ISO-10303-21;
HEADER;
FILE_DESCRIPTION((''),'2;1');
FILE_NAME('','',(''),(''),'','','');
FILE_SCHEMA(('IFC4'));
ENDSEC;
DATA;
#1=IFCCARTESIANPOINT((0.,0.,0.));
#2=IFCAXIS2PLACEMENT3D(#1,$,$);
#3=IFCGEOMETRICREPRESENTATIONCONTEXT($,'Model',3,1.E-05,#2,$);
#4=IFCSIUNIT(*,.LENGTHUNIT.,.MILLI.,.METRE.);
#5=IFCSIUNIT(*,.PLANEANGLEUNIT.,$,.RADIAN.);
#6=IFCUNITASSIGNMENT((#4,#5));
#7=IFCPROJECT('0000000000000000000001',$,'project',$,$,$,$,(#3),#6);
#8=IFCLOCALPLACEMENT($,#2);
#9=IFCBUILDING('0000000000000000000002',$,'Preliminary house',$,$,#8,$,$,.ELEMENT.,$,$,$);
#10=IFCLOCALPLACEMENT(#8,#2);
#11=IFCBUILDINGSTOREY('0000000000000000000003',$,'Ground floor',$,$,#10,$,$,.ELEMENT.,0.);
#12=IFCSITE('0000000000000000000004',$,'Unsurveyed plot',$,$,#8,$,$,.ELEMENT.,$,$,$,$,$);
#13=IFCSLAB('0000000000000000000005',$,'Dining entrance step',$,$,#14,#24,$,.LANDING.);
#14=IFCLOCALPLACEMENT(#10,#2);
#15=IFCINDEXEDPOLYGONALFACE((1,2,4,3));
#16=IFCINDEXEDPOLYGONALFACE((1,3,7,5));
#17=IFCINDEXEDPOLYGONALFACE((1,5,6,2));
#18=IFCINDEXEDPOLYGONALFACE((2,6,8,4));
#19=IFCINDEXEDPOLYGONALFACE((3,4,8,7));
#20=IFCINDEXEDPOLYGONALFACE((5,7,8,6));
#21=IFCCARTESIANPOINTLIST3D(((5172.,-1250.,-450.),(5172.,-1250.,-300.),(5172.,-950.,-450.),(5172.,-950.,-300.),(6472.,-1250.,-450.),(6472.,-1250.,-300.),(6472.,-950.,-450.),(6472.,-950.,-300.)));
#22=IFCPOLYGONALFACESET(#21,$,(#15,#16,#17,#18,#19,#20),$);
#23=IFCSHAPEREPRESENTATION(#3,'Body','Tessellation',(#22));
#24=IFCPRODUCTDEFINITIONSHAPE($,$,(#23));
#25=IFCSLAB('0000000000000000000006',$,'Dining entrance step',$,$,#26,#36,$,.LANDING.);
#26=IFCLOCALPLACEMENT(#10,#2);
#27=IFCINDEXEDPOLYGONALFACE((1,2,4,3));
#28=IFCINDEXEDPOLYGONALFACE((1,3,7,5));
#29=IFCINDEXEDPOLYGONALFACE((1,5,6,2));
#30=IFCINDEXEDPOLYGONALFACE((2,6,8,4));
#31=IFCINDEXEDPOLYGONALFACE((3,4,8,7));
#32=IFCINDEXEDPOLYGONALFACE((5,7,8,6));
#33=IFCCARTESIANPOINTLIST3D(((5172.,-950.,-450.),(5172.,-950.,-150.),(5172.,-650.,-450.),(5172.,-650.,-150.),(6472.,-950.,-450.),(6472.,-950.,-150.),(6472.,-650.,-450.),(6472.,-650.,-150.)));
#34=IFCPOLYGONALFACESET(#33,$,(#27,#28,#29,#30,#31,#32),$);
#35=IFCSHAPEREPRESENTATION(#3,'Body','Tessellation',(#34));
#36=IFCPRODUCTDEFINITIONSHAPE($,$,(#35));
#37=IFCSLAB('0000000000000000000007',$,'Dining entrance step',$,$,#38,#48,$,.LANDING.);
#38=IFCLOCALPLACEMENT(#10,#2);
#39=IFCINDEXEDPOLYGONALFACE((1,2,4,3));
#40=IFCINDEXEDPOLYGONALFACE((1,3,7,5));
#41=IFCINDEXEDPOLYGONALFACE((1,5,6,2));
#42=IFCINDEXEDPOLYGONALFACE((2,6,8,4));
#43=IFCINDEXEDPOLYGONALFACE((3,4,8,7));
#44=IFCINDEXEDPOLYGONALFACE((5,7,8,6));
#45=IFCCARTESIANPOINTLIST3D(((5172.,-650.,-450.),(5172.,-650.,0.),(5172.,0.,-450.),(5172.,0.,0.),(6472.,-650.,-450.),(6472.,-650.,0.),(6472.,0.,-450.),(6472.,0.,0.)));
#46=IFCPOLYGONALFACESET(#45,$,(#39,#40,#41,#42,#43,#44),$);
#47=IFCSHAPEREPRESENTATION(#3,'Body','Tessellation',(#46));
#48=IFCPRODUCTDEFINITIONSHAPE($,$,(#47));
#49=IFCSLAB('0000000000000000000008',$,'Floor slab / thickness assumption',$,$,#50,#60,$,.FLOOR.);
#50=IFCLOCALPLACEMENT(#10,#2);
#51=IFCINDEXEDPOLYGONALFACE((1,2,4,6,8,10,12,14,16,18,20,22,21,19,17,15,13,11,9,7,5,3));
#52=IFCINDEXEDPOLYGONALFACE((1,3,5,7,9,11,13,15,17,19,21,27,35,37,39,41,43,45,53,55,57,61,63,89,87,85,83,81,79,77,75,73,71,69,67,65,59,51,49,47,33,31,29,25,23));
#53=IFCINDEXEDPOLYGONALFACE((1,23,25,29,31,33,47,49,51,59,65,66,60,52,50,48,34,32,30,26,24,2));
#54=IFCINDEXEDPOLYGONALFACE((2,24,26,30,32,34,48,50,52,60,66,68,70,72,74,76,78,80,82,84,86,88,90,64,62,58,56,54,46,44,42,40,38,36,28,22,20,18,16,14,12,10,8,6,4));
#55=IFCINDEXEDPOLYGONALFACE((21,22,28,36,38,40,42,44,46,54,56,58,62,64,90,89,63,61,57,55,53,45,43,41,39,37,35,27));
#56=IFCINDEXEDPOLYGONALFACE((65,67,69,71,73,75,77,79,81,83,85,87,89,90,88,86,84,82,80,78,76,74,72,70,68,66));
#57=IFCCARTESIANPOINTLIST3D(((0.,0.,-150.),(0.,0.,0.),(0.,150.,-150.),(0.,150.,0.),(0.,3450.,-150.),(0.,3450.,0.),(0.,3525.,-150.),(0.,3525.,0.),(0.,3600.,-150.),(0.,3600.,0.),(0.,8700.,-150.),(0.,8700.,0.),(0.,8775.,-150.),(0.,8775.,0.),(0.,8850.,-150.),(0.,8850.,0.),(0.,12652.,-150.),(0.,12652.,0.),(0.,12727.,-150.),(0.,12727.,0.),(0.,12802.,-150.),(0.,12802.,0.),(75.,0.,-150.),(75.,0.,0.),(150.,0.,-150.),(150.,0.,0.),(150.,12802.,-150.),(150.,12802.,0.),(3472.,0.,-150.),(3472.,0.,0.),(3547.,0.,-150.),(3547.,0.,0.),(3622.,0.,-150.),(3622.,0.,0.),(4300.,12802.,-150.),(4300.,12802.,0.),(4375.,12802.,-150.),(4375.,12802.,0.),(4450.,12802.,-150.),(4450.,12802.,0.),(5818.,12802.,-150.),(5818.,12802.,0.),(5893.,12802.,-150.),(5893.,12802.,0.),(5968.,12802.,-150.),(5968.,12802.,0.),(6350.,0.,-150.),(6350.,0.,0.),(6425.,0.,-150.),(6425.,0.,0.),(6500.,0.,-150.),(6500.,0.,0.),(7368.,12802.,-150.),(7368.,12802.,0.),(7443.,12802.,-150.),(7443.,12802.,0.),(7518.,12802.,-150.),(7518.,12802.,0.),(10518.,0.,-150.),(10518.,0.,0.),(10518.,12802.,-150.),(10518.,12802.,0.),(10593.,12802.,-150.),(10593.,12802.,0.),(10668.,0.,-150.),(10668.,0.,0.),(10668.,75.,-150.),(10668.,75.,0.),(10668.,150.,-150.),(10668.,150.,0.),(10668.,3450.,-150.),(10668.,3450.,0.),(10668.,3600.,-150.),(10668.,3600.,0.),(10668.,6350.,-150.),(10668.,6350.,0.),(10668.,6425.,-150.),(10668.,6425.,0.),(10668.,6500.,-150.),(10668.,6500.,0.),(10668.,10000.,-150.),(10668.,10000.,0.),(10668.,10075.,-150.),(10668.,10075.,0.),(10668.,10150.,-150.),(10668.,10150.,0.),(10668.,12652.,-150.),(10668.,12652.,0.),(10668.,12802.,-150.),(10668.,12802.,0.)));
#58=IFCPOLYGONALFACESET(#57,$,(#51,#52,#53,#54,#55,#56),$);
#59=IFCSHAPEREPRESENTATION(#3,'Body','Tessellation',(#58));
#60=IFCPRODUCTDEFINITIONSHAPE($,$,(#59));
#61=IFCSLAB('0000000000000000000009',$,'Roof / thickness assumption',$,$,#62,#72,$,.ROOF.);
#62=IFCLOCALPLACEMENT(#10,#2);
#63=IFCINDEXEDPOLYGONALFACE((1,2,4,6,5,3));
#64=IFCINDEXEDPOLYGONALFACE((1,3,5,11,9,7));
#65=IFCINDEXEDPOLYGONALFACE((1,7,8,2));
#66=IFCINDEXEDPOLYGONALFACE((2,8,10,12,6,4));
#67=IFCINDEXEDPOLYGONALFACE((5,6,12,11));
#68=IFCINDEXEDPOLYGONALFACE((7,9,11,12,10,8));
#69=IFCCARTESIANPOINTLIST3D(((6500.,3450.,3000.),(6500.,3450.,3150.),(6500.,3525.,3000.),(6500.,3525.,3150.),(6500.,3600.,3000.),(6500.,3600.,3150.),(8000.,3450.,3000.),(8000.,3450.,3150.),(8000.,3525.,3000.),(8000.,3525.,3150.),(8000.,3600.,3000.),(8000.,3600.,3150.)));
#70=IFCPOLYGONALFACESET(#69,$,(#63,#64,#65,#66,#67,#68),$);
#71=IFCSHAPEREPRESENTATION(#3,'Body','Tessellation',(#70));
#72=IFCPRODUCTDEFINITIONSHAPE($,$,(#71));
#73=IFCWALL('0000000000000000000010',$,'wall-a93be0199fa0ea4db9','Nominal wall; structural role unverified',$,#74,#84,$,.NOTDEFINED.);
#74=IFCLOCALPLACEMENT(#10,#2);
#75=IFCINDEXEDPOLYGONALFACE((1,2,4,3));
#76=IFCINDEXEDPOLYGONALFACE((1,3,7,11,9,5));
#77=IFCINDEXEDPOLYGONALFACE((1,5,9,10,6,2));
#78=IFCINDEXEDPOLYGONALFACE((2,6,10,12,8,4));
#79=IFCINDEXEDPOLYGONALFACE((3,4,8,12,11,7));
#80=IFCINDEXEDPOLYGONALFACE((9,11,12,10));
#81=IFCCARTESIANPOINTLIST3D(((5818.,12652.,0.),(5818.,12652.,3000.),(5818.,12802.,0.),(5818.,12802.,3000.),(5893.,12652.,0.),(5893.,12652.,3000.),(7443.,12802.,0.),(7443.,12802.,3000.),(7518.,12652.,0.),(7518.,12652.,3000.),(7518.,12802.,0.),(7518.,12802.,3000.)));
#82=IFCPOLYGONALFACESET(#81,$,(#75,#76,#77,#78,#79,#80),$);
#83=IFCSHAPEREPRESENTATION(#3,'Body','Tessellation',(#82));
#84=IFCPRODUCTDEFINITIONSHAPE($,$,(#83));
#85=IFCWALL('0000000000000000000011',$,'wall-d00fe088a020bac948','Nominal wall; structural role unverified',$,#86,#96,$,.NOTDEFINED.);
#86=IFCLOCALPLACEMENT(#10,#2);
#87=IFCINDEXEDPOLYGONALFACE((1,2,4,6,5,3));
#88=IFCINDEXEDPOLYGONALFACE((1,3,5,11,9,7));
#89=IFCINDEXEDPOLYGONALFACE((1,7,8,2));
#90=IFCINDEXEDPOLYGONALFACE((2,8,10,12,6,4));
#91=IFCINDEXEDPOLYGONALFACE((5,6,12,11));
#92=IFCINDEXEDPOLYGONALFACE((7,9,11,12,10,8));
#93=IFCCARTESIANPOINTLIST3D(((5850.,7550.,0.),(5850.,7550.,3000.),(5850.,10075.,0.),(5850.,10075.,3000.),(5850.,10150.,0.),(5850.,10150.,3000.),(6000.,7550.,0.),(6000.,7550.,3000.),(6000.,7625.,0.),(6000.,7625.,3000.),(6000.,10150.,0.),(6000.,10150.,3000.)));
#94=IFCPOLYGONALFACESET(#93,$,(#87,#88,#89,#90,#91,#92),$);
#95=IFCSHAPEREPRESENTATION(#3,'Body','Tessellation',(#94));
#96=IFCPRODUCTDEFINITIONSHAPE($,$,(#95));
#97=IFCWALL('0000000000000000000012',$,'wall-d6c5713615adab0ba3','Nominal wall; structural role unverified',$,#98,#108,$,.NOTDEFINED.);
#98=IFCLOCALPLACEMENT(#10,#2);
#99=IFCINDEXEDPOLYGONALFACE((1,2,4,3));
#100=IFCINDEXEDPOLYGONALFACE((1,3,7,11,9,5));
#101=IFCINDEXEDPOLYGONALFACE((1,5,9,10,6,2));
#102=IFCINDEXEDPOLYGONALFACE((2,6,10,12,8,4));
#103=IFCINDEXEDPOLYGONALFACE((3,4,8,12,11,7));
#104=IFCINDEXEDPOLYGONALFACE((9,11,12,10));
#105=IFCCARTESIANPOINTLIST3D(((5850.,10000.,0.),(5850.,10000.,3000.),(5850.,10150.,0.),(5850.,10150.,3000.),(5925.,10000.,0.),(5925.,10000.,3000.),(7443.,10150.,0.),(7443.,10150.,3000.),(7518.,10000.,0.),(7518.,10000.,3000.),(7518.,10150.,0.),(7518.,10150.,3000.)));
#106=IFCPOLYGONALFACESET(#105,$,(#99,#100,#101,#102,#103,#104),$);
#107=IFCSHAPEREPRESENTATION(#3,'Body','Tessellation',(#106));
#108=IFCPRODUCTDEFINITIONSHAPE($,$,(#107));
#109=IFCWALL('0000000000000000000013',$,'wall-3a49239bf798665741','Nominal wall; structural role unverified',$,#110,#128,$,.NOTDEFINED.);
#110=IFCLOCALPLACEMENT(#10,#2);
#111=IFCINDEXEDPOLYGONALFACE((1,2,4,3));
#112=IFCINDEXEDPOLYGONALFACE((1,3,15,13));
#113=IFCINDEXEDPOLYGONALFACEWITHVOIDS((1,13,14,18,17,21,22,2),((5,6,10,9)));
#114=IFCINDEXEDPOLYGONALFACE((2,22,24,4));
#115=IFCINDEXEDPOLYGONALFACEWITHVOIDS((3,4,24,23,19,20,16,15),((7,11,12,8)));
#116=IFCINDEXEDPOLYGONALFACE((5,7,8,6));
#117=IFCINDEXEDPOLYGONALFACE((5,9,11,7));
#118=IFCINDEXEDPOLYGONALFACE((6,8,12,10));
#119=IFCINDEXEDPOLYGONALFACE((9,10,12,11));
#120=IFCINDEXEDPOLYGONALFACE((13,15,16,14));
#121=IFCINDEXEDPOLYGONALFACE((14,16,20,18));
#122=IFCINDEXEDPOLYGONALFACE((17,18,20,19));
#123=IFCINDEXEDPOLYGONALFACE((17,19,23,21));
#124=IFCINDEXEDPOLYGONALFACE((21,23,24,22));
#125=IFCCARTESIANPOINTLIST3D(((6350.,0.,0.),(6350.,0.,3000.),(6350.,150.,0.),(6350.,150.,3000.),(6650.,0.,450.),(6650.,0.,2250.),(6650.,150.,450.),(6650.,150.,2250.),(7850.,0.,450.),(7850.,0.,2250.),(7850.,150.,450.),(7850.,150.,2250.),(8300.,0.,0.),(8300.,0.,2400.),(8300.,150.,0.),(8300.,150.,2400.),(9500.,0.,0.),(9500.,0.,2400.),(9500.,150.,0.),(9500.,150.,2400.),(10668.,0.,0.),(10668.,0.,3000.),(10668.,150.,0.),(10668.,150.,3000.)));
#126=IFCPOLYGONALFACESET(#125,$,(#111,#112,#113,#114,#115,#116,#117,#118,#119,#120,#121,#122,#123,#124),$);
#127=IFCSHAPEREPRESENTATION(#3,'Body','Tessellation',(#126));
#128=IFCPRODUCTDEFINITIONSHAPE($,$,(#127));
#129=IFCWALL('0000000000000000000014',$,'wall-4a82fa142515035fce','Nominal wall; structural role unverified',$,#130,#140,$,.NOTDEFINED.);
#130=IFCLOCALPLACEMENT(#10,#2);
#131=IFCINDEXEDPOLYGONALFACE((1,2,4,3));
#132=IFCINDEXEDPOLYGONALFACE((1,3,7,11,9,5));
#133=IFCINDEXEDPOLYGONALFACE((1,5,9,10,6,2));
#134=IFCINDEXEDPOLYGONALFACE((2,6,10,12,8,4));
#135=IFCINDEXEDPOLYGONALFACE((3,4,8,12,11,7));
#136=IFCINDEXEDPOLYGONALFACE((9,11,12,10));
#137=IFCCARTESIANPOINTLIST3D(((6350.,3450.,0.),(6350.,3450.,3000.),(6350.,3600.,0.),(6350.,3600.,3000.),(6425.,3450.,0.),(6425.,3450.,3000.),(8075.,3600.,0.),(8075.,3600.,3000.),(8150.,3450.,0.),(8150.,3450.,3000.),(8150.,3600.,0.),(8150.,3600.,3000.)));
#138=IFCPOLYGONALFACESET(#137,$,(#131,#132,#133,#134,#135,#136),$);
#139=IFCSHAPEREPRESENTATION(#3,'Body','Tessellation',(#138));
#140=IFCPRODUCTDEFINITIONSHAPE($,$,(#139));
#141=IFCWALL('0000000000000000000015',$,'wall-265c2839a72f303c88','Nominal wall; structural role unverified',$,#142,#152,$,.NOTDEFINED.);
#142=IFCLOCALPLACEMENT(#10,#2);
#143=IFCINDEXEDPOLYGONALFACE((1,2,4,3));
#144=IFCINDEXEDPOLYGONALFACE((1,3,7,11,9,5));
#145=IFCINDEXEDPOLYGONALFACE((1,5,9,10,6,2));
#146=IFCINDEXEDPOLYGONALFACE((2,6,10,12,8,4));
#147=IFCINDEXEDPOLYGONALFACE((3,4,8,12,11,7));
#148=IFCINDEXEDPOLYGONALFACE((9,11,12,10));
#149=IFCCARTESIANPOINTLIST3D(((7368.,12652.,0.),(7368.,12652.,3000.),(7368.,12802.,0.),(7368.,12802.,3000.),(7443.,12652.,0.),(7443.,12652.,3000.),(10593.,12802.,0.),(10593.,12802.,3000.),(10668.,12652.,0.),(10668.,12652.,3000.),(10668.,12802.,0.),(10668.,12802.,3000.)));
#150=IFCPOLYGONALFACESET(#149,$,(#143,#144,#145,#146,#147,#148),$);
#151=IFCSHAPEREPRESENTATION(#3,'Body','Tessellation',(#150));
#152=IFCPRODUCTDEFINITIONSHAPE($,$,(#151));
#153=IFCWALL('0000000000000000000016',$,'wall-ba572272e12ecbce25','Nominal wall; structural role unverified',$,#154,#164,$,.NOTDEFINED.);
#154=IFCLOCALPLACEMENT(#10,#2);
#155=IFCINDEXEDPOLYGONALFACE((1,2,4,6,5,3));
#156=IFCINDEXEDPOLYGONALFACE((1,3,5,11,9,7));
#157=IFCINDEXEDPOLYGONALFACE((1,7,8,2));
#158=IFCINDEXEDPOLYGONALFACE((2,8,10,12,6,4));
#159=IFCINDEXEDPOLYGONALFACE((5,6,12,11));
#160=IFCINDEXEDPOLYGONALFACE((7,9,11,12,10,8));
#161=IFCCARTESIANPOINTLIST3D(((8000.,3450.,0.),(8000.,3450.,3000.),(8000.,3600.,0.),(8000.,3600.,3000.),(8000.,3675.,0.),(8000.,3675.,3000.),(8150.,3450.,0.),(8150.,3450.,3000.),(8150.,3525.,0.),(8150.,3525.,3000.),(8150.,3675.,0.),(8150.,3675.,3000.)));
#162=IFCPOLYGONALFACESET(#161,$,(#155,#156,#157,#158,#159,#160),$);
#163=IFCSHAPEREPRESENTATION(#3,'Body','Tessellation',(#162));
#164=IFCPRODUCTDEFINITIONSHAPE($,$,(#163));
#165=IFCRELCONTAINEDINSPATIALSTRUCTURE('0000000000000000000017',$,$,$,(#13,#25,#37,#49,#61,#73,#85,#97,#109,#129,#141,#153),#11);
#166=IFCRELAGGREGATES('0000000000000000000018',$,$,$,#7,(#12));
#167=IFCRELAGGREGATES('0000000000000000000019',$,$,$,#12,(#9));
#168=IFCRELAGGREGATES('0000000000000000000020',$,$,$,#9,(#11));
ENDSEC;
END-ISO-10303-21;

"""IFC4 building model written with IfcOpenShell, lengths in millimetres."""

from ifc_helpers import new_model, si_unit, frame, origin, place, context, project, spatial, polyline, outline, extrude, element, save


model = new_model("IFC4")

# Units and contexts
model_context = context("Model", 3, precision=1e-05, world=origin())
ifc_project = project(units=[si_unit("LENGTHUNIT", "METRE", prefix="MILLI"), si_unit("PLANEANGLEUNIT", "RADIAN")], contexts=[model_context])

# Site, building, storey
placement_1 = place(None, origin())
site = spatial("IfcSite", under=ifc_project, at=placement_1, Name="Unsurveyed plot", CompositionType="ELEMENT")
building = spatial("IfcBuilding", under=site, at=placement_1, Name="Preliminary house", CompositionType="ELEMENT")
placement_2 = place(placement_1, origin())
storey = spatial("IfcBuildingStorey", under=building, at=placement_2, Name="Ground floor", CompositionType="ELEMENT", Elevation=0.0)

# Slabs
element("IfcSlab", 1, at=placement_2, inside=storey, Name="Dining entrance step", PredefinedType="LANDING", context=model_context, shape_type="SweptSolid", body=[
    extrude(outline(polyline([(5172.0, -1250.0), (6472.0, -1250.0), (6472.0, -950.0), (5172.0, -950.0), (5172.0, -1250.0)])), frame((0.0, 0.0, -450.0)), (0.0, 0.0, 1.0), 150.0),
])
element("IfcSlab", 2, at=placement_2, inside=storey, Name="Dining entrance step", PredefinedType="LANDING", context=model_context, shape_type="SweptSolid", body=[
    extrude(outline(polyline([(5172.0, -950.0), (6472.0, -950.0), (6472.0, -650.0), (5172.0, -650.0), (5172.0, -950.0)])), frame((0.0, 0.0, -450.0)), (0.0, 0.0, 1.0), 300.0),
])
element("IfcSlab", 3, at=placement_2, inside=storey, Name="Dining entrance step", PredefinedType="LANDING", context=model_context, shape_type="SweptSolid", body=[
    extrude(outline(polyline([(5172.0, -650.0), (6472.0, -650.0), (6472.0, 0.0), (5172.0, 0.0), (5172.0, -650.0)])), frame((0.0, 0.0, -450.0)), (0.0, 0.0, 1.0), 450.0),
])
element("IfcSlab", 4, at=placement_2, inside=storey, Name="Floor slab / thickness assumption", PredefinedType="FLOOR", context=model_context, shape_type="SweptSolid", body=[
    extrude(outline(polyline([(3472.0, 0.0), (150.0, 0.0), (75.0, 0.0), (0.0, 0.0), (0.0, 150.0), (0.0, 3450.0), (0.0, 3525.0), (0.0, 3600.0), (0.0, 8700.0), (0.0, 8775.0), (0.0, 8850.0), (0.0, 12652.0), (0.0, 12727.0), (0.0, 12802.0), (150.0, 12802.0), (4300.0, 12802.0), (4375.0, 12802.0), (4450.0, 12802.0), (5818.0, 12802.0), (5893.0, 12802.0), (5968.0, 12802.0), (7368.0, 12802.0), (7443.0, 12802.0), (7518.0, 12802.0), (10518.0, 12802.0), (10593.0, 12802.0), (10668.0, 12802.0), (10668.0, 12652.0), (10668.0, 10150.0), (10668.0, 10075.0), (10668.0, 10000.0), (10668.0, 6500.0), (10668.0, 6425.0), (10668.0, 6350.0), (10668.0, 3600.0), (10668.0, 3450.0), (10668.0, 150.0), (10668.0, 75.0), (10668.0, 0.0), (10518.0, 0.0), (6500.0, 0.0), (6425.0, 0.0), (6350.0, 0.0), (3622.0, 0.0), (3547.0, 0.0), (3472.0, 0.0)])), frame((0.0, 0.0, -150.0)), (0.0, 0.0, 1.0), 150.0),
])
element("IfcSlab", 5, at=placement_2, inside=storey, Name="Roof / thickness assumption", PredefinedType="ROOF", context=model_context, shape_type="SweptSolid", body=[
    extrude(outline(polyline([(8000.0, 3600.0), (8000.0, 3525.0), (8000.0, 3450.0), (6500.0, 3450.0), (6500.0, 3525.0), (6500.0, 3600.0), (8000.0, 3600.0)])), frame((0.0, 0.0, 3000.0)), (0.0, 0.0, 1.0), 150.0),
])

# Walls
element("IfcWall", 6, at=placement_2, inside=storey, Name="wall-a93be0199fa0ea4db9", Description="Nominal wall; structural role unverified", PredefinedType="NOTDEFINED", context=model_context, shape_type="SweptSolid", body=[
    extrude(outline(polyline([(7443.0, 12802.0), (7518.0, 12802.0), (7518.0, 12652.0), (5893.0, 12652.0), (5818.0, 12652.0), (5818.0, 12802.0), (7443.0, 12802.0)])), origin(), (0.0, 0.0, 1.0), 3000.0),
])
element("IfcWall", 7, at=placement_2, inside=storey, Name="wall-d00fe088a020bac948", Description="Nominal wall; structural role unverified", PredefinedType="NOTDEFINED", context=model_context, shape_type="SweptSolid", body=[
    extrude(outline(polyline([(5850.0, 10075.0), (5850.0, 10150.0), (6000.0, 10150.0), (6000.0, 7625.0), (6000.0, 7550.0), (5850.0, 7550.0), (5850.0, 10075.0)])), origin(), (0.0, 0.0, 1.0), 3000.0),
])
element("IfcWall", 8, at=placement_2, inside=storey, Name="wall-d6c5713615adab0ba3", Description="Nominal wall; structural role unverified", PredefinedType="NOTDEFINED", context=model_context, shape_type="SweptSolid", body=[
    extrude(outline(polyline([(7443.0, 10150.0), (7518.0, 10150.0), (7518.0, 10000.0), (5925.0, 10000.0), (5850.0, 10000.0), (5850.0, 10150.0), (7443.0, 10150.0)])), origin(), (0.0, 0.0, 1.0), 3000.0),
])

# Wall, openings
wall_1 = element("IfcWall", 9, at=placement_2, inside=storey, Name="wall-3a49239bf798665741", Description="Nominal wall; structural role unverified", PredefinedType="NOTDEFINED", context=model_context, shape_type="SweptSolid", body=[
    extrude(outline(polyline([(10593.0, 150.0), (10668.0, 150.0), (10668.0, 0.0), (6425.0, 0.0), (6350.0, 0.0), (6350.0, 150.0), (10593.0, 150.0)])), origin(), (0.0, 0.0, 1.0), 3000.0),
])
element("IfcOpeningElement", 10, at=placement_2, cuts=wall_1, PredefinedType="OPENING", context=model_context, shape_type="SweptSolid", body=[
    extrude(outline(polyline([(6650.0, -375.0), (7850.0, -375.0), (7850.0, 525.0), (6650.0, 525.0), (6650.0, -375.0)])), frame((0.0, 0.0, 450.0)), (0.0, 0.0, 1.0), 1800.0),
])
element("IfcOpeningElement", 11, at=placement_2, cuts=wall_1, PredefinedType="OPENING", context=model_context, shape_type="SweptSolid", body=[
    extrude(outline(polyline([(8300.0, -375.0), (9500.0, -375.0), (9500.0, 525.0), (8300.0, 525.0), (8300.0, -375.0)])), origin(), (0.0, 0.0, 1.0), 2400.0),
])

# Wall
element("IfcWall", 12, at=placement_2, inside=storey, Name="wall-4a82fa142515035fce", Description="Nominal wall; structural role unverified", PredefinedType="NOTDEFINED", context=model_context, shape_type="SweptSolid", body=[
    extrude(outline(polyline([(8075.0, 3600.0), (8150.0, 3600.0), (8150.0, 3450.0), (6425.0, 3450.0), (6350.0, 3450.0), (6350.0, 3600.0), (8075.0, 3600.0)])), origin(), (0.0, 0.0, 1.0), 3000.0),
])

# Walls
element("IfcWall", 13, at=placement_2, inside=storey, Name="wall-265c2839a72f303c88", Description="Nominal wall; structural role unverified", PredefinedType="NOTDEFINED", context=model_context, shape_type="SweptSolid", body=[
    extrude(outline(polyline([(10593.0, 12802.0), (10668.0, 12802.0), (10668.0, 12652.0), (7443.0, 12652.0), (7368.0, 12652.0), (7368.0, 12802.0), (10593.0, 12802.0)])), origin(), (0.0, 0.0, 1.0), 3000.0),
])
element("IfcWall", 14, at=placement_2, inside=storey, Name="wall-ba572272e12ecbce25", Description="Nominal wall; structural role unverified", PredefinedType="NOTDEFINED", context=model_context, shape_type="SweptSolid", body=[
    extrude(outline(polyline([(8000.0, 3600.0), (8000.0, 3675.0), (8150.0, 3675.0), (8150.0, 3525.0), (8150.0, 3450.0), (8000.0, 3450.0), (8000.0, 3600.0)])), origin(), (0.0, 0.0, 1.0), 3000.0),
])

save(model, "model.ifc")
